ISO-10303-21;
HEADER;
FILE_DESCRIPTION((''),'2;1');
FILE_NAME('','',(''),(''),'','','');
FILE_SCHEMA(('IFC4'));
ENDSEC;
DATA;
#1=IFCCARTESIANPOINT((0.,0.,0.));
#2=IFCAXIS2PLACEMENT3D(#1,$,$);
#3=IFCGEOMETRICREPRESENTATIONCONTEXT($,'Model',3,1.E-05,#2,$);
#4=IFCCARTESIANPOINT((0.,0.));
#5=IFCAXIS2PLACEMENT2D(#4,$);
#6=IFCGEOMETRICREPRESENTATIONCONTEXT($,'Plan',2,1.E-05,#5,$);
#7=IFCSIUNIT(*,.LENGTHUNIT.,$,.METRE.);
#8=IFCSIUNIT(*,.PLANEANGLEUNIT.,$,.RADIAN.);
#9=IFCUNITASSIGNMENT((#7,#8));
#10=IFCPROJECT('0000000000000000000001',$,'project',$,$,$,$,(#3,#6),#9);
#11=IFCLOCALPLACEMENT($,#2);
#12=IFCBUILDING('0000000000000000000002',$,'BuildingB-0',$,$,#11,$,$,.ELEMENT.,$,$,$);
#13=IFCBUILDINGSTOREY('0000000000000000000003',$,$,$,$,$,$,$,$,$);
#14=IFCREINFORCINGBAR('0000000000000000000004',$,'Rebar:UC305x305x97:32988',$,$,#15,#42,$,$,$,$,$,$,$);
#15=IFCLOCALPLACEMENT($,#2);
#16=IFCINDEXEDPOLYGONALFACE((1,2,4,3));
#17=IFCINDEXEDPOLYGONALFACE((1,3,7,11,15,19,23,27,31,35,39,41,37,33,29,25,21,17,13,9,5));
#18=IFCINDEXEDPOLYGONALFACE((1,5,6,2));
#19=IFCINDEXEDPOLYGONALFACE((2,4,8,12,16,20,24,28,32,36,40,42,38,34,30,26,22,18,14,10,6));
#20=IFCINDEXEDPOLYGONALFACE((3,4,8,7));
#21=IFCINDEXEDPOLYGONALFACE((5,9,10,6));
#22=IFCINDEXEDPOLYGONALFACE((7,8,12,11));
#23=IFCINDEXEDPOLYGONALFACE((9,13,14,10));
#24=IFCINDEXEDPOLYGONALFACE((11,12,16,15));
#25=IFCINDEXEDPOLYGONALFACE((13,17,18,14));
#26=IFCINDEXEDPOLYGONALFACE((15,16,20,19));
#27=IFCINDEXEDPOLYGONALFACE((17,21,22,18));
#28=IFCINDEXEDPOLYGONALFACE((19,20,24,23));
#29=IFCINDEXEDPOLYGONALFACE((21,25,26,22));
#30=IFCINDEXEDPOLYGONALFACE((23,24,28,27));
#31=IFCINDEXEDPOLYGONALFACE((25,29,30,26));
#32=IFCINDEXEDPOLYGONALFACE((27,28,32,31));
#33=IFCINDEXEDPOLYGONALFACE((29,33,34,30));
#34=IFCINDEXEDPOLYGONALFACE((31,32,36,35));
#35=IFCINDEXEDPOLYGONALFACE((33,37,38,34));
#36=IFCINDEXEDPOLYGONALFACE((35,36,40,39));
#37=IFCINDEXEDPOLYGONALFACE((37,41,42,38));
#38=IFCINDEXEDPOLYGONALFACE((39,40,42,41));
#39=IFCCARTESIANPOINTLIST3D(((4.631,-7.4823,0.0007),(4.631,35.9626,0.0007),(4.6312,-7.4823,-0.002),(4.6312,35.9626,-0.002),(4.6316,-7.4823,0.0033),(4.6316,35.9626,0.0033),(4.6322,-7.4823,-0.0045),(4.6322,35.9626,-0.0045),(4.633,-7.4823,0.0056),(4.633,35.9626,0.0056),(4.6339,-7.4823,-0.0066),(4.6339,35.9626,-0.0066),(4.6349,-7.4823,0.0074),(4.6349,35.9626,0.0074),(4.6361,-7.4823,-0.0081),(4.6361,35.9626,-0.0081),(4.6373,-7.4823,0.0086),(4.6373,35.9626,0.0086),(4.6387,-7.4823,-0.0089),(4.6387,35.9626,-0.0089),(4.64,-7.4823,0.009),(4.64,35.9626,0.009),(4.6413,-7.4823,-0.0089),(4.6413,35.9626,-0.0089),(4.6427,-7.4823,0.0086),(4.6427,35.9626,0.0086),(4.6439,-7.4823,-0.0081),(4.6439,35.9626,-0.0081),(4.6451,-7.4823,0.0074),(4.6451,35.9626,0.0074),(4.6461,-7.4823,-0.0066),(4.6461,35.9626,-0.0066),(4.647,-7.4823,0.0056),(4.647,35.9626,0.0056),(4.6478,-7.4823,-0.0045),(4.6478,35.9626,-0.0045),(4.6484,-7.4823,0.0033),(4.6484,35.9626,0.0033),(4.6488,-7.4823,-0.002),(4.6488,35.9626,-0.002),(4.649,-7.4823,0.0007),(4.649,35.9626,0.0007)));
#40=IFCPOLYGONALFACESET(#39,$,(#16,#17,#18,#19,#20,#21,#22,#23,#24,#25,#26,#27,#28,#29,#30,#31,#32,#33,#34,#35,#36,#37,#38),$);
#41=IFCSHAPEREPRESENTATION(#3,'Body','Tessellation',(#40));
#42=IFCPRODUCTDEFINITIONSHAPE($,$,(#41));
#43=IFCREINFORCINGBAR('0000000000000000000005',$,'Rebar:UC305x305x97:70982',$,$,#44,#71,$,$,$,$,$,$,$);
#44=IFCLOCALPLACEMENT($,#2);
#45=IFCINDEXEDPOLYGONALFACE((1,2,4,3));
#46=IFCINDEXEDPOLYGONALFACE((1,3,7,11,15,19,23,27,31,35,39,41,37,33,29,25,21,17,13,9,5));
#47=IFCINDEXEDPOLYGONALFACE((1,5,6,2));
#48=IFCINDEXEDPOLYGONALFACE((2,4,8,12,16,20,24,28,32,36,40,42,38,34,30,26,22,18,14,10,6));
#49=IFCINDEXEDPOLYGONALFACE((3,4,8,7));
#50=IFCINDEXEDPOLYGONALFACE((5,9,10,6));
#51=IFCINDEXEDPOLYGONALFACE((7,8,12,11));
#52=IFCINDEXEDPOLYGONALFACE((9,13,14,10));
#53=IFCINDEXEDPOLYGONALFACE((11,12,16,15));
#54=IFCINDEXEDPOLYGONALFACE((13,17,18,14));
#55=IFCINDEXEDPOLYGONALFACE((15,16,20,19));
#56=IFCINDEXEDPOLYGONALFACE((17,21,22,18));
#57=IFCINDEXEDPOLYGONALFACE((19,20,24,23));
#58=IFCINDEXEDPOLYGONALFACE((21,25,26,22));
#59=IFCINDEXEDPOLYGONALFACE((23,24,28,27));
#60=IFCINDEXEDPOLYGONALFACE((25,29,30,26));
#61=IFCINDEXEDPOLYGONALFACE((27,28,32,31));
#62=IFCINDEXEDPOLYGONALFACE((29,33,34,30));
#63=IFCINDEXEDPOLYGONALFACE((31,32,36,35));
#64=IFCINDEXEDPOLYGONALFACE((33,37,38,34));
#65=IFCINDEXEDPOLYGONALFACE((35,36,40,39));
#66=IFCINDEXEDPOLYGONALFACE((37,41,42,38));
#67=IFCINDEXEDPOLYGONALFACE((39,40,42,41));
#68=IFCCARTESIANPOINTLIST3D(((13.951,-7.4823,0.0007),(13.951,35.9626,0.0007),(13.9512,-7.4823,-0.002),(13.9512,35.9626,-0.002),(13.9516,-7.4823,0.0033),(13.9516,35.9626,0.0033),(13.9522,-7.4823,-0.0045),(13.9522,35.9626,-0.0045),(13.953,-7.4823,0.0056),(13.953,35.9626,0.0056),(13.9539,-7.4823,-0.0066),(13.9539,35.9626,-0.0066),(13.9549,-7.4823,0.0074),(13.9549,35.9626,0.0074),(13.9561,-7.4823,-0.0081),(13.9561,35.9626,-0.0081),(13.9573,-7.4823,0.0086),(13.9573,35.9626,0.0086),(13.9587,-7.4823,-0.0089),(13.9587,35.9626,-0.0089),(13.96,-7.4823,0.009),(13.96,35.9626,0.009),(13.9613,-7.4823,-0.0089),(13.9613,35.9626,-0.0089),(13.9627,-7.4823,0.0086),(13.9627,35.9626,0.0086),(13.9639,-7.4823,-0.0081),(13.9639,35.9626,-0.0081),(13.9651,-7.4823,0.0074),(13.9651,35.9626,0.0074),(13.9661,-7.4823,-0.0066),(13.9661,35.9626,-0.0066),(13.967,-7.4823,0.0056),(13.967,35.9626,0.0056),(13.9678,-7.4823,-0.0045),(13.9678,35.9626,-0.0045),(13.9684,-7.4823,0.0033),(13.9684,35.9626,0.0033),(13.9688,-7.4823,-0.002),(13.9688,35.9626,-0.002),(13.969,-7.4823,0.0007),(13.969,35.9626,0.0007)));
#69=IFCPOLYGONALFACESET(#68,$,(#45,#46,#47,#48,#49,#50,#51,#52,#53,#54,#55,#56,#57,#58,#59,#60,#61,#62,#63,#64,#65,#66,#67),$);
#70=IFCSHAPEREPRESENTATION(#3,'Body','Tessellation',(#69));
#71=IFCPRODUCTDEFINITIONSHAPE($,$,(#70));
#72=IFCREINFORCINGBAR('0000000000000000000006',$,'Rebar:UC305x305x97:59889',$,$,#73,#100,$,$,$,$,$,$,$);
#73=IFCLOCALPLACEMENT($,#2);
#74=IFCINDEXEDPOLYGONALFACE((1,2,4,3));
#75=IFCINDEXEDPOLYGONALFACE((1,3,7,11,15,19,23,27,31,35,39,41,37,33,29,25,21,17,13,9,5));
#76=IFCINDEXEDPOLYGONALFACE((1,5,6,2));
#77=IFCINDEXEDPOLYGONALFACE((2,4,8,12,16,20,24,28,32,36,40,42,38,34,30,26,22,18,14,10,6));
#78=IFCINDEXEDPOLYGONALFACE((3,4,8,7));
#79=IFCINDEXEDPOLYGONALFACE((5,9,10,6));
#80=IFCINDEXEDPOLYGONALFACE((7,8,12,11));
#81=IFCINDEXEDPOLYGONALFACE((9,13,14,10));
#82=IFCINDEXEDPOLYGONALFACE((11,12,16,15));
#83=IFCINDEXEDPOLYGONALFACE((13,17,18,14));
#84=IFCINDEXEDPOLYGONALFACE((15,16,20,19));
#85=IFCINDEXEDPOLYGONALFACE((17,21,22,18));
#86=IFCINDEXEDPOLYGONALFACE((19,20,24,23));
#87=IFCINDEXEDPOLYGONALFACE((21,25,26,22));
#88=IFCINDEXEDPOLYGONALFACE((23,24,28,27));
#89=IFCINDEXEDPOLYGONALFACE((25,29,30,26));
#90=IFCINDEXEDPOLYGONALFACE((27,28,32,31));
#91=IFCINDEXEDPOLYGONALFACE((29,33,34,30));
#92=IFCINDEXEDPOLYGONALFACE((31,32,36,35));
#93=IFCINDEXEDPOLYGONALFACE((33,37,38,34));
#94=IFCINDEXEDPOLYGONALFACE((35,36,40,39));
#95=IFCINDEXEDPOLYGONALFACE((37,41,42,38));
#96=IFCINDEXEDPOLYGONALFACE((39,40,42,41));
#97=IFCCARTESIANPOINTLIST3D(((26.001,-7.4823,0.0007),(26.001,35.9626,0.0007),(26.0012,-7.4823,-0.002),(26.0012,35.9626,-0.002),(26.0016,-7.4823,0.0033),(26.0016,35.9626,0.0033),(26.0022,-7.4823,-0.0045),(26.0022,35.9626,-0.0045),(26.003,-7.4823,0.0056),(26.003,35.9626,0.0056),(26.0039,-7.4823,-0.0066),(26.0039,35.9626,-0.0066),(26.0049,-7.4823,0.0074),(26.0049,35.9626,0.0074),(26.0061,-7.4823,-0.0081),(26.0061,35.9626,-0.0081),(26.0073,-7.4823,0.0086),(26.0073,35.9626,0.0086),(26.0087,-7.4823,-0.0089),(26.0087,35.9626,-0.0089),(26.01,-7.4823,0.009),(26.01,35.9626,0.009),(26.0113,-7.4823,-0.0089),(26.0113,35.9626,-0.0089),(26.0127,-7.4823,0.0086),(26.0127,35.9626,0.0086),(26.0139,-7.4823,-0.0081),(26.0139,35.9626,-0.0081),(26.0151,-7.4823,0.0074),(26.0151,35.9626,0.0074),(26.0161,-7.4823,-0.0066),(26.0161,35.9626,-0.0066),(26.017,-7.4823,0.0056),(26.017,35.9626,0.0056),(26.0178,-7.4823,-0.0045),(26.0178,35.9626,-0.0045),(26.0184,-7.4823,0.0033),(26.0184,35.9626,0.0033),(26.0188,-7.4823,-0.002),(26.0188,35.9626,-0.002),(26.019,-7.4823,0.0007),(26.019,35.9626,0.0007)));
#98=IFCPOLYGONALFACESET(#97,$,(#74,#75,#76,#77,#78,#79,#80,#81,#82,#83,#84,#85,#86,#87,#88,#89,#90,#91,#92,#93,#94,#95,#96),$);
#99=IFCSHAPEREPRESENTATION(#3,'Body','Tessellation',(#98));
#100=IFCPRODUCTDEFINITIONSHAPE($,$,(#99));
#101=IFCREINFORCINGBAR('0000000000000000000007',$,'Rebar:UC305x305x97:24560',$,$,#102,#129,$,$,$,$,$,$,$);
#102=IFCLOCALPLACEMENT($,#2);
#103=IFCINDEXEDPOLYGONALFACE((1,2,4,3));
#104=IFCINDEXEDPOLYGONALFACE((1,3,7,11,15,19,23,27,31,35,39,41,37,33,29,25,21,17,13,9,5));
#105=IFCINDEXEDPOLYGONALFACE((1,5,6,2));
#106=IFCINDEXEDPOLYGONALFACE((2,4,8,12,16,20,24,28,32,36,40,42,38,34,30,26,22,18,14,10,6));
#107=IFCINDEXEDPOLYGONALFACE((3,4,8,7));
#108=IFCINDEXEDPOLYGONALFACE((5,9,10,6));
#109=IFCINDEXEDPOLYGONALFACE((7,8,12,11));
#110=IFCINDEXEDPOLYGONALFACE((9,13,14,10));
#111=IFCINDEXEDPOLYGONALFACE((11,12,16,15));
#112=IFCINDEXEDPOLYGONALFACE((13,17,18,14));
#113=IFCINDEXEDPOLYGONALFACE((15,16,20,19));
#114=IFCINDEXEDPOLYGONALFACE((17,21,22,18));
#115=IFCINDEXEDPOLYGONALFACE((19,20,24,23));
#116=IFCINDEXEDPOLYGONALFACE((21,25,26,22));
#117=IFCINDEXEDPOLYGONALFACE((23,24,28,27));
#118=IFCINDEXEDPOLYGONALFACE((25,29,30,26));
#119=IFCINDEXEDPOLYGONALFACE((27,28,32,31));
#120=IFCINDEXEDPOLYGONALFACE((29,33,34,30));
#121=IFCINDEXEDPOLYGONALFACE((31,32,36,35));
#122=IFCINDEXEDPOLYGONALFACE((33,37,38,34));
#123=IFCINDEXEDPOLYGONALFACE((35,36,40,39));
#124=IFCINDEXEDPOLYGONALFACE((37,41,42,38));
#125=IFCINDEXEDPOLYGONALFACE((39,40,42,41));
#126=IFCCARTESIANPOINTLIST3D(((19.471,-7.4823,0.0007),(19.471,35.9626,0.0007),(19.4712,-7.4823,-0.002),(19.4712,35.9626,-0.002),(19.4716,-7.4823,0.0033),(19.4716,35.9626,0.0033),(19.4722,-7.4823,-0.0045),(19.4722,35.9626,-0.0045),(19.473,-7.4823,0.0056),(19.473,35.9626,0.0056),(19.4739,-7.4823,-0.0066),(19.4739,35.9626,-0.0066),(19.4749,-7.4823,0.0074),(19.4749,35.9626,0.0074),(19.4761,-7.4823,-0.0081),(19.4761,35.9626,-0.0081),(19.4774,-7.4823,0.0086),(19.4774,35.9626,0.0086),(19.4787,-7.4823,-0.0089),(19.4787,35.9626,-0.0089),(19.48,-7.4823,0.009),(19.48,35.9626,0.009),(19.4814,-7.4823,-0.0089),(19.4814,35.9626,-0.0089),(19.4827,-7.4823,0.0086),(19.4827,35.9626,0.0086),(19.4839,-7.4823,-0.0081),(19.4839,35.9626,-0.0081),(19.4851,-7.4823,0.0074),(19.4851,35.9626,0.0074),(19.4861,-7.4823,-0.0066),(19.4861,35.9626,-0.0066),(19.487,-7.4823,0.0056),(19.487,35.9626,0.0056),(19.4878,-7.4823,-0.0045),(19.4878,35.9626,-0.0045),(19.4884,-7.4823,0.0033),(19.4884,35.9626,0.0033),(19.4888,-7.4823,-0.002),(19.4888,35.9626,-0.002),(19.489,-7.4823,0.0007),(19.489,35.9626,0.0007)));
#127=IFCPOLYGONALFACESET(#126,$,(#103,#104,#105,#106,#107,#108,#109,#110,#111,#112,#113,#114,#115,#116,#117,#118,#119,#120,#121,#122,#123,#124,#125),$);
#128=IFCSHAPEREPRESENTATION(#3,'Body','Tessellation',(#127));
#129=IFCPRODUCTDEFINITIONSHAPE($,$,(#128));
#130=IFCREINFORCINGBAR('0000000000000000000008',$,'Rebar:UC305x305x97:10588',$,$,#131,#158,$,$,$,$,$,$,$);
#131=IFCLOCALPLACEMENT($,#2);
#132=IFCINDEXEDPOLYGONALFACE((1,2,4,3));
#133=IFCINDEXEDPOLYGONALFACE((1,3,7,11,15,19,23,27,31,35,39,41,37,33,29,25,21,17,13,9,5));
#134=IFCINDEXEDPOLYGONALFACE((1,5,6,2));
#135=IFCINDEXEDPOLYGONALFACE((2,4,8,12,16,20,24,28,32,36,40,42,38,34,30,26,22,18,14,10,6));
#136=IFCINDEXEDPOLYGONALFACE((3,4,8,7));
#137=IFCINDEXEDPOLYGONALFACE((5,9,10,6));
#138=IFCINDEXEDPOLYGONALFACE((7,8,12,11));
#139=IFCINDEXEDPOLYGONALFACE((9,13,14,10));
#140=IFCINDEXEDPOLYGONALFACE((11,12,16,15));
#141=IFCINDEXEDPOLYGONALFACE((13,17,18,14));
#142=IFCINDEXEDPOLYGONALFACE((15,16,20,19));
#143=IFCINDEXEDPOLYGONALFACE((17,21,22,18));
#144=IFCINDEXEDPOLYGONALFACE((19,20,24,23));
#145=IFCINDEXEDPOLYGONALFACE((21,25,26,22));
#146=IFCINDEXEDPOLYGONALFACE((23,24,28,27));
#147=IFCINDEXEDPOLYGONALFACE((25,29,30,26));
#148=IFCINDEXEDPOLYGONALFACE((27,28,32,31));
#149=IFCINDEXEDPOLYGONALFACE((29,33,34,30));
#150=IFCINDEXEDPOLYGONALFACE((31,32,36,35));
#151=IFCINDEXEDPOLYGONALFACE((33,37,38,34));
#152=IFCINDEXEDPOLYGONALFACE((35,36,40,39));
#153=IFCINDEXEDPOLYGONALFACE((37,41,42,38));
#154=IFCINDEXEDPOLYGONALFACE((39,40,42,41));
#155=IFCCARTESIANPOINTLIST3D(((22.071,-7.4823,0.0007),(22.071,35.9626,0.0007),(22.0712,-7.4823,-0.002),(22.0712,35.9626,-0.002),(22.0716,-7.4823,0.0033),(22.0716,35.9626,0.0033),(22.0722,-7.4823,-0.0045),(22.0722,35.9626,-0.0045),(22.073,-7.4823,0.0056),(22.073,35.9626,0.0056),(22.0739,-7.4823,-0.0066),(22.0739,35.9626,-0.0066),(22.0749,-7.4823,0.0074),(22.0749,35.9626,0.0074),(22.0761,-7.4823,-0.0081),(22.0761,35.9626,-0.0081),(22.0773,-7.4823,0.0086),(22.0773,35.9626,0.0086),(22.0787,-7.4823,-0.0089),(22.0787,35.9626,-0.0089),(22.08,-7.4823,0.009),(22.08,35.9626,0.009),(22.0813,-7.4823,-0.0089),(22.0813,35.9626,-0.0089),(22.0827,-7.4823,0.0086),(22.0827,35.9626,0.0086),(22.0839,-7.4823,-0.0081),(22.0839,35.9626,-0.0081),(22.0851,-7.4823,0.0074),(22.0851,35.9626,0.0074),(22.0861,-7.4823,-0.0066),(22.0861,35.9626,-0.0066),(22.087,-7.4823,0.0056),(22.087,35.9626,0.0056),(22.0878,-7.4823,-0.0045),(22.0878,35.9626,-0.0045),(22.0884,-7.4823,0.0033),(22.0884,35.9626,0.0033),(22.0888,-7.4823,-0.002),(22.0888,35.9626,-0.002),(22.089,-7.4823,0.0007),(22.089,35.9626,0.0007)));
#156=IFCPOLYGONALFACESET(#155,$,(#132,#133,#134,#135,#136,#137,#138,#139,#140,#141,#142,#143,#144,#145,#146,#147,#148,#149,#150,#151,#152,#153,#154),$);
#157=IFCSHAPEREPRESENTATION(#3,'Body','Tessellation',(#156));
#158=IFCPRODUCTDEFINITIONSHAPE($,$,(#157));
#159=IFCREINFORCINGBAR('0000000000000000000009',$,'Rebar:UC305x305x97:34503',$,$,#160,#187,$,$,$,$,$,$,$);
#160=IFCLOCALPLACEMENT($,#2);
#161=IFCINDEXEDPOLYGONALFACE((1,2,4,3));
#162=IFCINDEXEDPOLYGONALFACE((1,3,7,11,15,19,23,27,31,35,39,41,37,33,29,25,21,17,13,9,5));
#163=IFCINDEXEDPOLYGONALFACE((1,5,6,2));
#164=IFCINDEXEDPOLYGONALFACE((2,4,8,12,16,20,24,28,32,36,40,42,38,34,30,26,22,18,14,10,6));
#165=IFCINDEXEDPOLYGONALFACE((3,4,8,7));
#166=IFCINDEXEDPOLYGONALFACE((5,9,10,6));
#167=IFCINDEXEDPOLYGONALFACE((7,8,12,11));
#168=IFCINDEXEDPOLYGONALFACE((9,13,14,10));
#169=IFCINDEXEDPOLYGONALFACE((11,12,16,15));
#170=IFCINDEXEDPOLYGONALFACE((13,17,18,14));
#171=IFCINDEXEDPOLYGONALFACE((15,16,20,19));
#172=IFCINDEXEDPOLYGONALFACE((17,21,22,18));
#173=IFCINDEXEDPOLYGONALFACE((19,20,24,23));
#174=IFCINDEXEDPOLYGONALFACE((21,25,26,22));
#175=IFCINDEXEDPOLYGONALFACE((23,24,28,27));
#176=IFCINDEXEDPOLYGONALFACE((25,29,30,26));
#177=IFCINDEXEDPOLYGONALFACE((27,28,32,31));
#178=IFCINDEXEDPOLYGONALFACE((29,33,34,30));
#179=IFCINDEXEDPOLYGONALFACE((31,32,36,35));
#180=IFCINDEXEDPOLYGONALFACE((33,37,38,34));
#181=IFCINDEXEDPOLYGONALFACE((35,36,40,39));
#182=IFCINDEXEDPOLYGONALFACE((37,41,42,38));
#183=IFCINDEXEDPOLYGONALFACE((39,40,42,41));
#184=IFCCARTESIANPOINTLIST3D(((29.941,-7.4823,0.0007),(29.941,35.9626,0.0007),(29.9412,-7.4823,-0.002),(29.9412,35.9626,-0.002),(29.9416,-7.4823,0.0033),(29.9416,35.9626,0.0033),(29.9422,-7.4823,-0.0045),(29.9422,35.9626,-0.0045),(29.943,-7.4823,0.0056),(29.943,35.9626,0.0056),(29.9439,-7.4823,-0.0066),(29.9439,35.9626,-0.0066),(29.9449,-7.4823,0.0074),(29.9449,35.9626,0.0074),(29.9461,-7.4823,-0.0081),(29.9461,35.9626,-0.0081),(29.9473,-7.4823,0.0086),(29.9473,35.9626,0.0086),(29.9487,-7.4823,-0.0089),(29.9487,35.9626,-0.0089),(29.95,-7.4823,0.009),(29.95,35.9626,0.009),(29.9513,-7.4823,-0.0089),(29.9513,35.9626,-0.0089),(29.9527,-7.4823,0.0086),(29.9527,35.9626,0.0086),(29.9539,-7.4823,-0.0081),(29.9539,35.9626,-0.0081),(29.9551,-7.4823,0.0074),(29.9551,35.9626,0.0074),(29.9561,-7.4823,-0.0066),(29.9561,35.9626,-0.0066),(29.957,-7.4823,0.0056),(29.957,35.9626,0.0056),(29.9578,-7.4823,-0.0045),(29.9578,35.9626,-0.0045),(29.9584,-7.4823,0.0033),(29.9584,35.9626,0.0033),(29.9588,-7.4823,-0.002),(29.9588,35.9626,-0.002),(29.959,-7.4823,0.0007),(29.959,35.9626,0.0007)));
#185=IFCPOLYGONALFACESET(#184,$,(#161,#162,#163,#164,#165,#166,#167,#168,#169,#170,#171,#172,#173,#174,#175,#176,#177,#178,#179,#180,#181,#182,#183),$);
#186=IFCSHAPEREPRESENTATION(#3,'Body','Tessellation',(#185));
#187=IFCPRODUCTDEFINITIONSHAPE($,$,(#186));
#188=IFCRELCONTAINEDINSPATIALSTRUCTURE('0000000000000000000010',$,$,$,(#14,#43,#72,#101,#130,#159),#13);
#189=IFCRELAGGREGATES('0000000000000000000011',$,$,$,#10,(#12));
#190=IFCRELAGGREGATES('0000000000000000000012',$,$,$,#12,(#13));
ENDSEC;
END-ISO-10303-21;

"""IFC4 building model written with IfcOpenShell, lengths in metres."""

from ifc_helpers import new_model, entity, si_unit, origin, origin_2d, place, context, project, spatial, element, save


model = new_model("IFC4")

# Units and contexts
model_context = context("Model", 3, precision=1e-05, world=origin())
plan_context = context("Plan", 2, precision=1e-05, world=origin_2d())
ifc_project = project(units=[si_unit("LENGTHUNIT", "METRE"), si_unit("PLANEANGLEUNIT", "RADIAN")], contexts=[model_context, plan_context])

# Building, storey
building_placement = place(None, origin())
building = spatial("IfcBuilding", under=ifc_project, at=building_placement, Name="BuildingB-0", CompositionType="ELEMENT")
storey = spatial("IfcBuildingStorey", under=building)

# Reinforcing bars
element("IfcReinforcingBar", 1, inside=storey, Name="Rebar:UC305x305x97:32988", context=model_context, shape_type="SweptSolid", body=[
    entity("IfcSurfaceCurveSweptAreaSolid", entity("IfcCircleProfileDef", "AREA", None, None, 0.009), None, entity("IfcPolyline", [entity("IfcCartesianPoint", [4.64, 35.9626, 0.0]), entity("IfcCartesianPoint", [4.64, -7.4823, 0.0])]), None, None, entity("IfcPlane", entity("IfcAxis2Placement3D", entity("IfcCartesianPoint", [4.64, 35.9626, 0.0]), entity("IfcDirection", [0.0, 0.0, 1.0]), entity("IfcDirection", [1.0, 0.0, 0.0])))),
])
element("IfcReinforcingBar", 2, inside=storey, Name="Rebar:UC305x305x97:70982", context=model_context, shape_type="SweptSolid", body=[
    entity("IfcSurfaceCurveSweptAreaSolid", entity("IfcCircleProfileDef", "AREA", None, None, 0.009), None, entity("IfcPolyline", [entity("IfcCartesianPoint", [13.96, 35.9626, 0.0]), entity("IfcCartesianPoint", [13.96, -7.4823, 0.0])]), None, None, entity("IfcPlane", entity("IfcAxis2Placement3D", entity("IfcCartesianPoint", [13.96, 35.9626, 0.0]), entity("IfcDirection", [0.0, 0.0, 1.0]), entity("IfcDirection", [1.0, 0.0, 0.0])))),
])
element("IfcReinforcingBar", 3, inside=storey, Name="Rebar:UC305x305x97:59889", context=model_context, shape_type="SweptSolid", body=[
    entity("IfcSurfaceCurveSweptAreaSolid", entity("IfcCircleProfileDef", "AREA", None, None, 0.009), None, entity("IfcPolyline", [entity("IfcCartesianPoint", [26.01, 35.9626, 0.0]), entity("IfcCartesianPoint", [26.01, -7.4823, 0.0])]), None, None, entity("IfcPlane", entity("IfcAxis2Placement3D", entity("IfcCartesianPoint", [26.01, 35.9626, 0.0]), entity("IfcDirection", [0.0, 0.0, 1.0]), entity("IfcDirection", [1.0, 0.0, 0.0])))),
])
element("IfcReinforcingBar", 4, inside=storey, Name="Rebar:UC305x305x97:24560", context=model_context, shape_type="SweptSolid", body=[
    entity("IfcSurfaceCurveSweptAreaSolid", entity("IfcCircleProfileDef", "AREA", None, None, 0.009), None, entity("IfcPolyline", [entity("IfcCartesianPoint", [19.48, 35.9626, 0.0]), entity("IfcCartesianPoint", [19.48, -7.4823, 0.0])]), None, None, entity("IfcPlane", entity("IfcAxis2Placement3D", entity("IfcCartesianPoint", [19.48, 35.9626, 0.0]), entity("IfcDirection", [0.0, 0.0, 1.0]), entity("IfcDirection", [1.0, 0.0, 0.0])))),
])
element("IfcReinforcingBar", 5, inside=storey, Name="Rebar:UC305x305x97:10588", context=model_context, shape_type="SweptSolid", body=[
    entity("IfcSurfaceCurveSweptAreaSolid", entity("IfcCircleProfileDef", "AREA", None, None, 0.009), None, entity("IfcPolyline", [entity("IfcCartesianPoint", [22.08, 35.9626, 0.0]), entity("IfcCartesianPoint", [22.08, -7.4823, 0.0])]), None, None, entity("IfcPlane", entity("IfcAxis2Placement3D", entity("IfcCartesianPoint", [22.08, 35.9626, 0.0]), entity("IfcDirection", [0.0, 0.0, 1.0]), entity("IfcDirection", [1.0, 0.0, 0.0])))),
])
element("IfcReinforcingBar", 6, inside=storey, Name="Rebar:UC305x305x97:34503", context=model_context, shape_type="SweptSolid", body=[
    entity("IfcSurfaceCurveSweptAreaSolid", entity("IfcCircleProfileDef", "AREA", None, None, 0.009), None, entity("IfcPolyline", [entity("IfcCartesianPoint", [29.95, 35.9626, 0.0]), entity("IfcCartesianPoint", [29.95, -7.4823, 0.0])]), None, None, entity("IfcPlane", entity("IfcAxis2Placement3D", entity("IfcCartesianPoint", [29.95, 35.9626, 0.0]), entity("IfcDirection", [0.0, 0.0, 1.0]), entity("IfcDirection", [1.0, 0.0, 0.0])))),
])

save(model, "model.ifc")
